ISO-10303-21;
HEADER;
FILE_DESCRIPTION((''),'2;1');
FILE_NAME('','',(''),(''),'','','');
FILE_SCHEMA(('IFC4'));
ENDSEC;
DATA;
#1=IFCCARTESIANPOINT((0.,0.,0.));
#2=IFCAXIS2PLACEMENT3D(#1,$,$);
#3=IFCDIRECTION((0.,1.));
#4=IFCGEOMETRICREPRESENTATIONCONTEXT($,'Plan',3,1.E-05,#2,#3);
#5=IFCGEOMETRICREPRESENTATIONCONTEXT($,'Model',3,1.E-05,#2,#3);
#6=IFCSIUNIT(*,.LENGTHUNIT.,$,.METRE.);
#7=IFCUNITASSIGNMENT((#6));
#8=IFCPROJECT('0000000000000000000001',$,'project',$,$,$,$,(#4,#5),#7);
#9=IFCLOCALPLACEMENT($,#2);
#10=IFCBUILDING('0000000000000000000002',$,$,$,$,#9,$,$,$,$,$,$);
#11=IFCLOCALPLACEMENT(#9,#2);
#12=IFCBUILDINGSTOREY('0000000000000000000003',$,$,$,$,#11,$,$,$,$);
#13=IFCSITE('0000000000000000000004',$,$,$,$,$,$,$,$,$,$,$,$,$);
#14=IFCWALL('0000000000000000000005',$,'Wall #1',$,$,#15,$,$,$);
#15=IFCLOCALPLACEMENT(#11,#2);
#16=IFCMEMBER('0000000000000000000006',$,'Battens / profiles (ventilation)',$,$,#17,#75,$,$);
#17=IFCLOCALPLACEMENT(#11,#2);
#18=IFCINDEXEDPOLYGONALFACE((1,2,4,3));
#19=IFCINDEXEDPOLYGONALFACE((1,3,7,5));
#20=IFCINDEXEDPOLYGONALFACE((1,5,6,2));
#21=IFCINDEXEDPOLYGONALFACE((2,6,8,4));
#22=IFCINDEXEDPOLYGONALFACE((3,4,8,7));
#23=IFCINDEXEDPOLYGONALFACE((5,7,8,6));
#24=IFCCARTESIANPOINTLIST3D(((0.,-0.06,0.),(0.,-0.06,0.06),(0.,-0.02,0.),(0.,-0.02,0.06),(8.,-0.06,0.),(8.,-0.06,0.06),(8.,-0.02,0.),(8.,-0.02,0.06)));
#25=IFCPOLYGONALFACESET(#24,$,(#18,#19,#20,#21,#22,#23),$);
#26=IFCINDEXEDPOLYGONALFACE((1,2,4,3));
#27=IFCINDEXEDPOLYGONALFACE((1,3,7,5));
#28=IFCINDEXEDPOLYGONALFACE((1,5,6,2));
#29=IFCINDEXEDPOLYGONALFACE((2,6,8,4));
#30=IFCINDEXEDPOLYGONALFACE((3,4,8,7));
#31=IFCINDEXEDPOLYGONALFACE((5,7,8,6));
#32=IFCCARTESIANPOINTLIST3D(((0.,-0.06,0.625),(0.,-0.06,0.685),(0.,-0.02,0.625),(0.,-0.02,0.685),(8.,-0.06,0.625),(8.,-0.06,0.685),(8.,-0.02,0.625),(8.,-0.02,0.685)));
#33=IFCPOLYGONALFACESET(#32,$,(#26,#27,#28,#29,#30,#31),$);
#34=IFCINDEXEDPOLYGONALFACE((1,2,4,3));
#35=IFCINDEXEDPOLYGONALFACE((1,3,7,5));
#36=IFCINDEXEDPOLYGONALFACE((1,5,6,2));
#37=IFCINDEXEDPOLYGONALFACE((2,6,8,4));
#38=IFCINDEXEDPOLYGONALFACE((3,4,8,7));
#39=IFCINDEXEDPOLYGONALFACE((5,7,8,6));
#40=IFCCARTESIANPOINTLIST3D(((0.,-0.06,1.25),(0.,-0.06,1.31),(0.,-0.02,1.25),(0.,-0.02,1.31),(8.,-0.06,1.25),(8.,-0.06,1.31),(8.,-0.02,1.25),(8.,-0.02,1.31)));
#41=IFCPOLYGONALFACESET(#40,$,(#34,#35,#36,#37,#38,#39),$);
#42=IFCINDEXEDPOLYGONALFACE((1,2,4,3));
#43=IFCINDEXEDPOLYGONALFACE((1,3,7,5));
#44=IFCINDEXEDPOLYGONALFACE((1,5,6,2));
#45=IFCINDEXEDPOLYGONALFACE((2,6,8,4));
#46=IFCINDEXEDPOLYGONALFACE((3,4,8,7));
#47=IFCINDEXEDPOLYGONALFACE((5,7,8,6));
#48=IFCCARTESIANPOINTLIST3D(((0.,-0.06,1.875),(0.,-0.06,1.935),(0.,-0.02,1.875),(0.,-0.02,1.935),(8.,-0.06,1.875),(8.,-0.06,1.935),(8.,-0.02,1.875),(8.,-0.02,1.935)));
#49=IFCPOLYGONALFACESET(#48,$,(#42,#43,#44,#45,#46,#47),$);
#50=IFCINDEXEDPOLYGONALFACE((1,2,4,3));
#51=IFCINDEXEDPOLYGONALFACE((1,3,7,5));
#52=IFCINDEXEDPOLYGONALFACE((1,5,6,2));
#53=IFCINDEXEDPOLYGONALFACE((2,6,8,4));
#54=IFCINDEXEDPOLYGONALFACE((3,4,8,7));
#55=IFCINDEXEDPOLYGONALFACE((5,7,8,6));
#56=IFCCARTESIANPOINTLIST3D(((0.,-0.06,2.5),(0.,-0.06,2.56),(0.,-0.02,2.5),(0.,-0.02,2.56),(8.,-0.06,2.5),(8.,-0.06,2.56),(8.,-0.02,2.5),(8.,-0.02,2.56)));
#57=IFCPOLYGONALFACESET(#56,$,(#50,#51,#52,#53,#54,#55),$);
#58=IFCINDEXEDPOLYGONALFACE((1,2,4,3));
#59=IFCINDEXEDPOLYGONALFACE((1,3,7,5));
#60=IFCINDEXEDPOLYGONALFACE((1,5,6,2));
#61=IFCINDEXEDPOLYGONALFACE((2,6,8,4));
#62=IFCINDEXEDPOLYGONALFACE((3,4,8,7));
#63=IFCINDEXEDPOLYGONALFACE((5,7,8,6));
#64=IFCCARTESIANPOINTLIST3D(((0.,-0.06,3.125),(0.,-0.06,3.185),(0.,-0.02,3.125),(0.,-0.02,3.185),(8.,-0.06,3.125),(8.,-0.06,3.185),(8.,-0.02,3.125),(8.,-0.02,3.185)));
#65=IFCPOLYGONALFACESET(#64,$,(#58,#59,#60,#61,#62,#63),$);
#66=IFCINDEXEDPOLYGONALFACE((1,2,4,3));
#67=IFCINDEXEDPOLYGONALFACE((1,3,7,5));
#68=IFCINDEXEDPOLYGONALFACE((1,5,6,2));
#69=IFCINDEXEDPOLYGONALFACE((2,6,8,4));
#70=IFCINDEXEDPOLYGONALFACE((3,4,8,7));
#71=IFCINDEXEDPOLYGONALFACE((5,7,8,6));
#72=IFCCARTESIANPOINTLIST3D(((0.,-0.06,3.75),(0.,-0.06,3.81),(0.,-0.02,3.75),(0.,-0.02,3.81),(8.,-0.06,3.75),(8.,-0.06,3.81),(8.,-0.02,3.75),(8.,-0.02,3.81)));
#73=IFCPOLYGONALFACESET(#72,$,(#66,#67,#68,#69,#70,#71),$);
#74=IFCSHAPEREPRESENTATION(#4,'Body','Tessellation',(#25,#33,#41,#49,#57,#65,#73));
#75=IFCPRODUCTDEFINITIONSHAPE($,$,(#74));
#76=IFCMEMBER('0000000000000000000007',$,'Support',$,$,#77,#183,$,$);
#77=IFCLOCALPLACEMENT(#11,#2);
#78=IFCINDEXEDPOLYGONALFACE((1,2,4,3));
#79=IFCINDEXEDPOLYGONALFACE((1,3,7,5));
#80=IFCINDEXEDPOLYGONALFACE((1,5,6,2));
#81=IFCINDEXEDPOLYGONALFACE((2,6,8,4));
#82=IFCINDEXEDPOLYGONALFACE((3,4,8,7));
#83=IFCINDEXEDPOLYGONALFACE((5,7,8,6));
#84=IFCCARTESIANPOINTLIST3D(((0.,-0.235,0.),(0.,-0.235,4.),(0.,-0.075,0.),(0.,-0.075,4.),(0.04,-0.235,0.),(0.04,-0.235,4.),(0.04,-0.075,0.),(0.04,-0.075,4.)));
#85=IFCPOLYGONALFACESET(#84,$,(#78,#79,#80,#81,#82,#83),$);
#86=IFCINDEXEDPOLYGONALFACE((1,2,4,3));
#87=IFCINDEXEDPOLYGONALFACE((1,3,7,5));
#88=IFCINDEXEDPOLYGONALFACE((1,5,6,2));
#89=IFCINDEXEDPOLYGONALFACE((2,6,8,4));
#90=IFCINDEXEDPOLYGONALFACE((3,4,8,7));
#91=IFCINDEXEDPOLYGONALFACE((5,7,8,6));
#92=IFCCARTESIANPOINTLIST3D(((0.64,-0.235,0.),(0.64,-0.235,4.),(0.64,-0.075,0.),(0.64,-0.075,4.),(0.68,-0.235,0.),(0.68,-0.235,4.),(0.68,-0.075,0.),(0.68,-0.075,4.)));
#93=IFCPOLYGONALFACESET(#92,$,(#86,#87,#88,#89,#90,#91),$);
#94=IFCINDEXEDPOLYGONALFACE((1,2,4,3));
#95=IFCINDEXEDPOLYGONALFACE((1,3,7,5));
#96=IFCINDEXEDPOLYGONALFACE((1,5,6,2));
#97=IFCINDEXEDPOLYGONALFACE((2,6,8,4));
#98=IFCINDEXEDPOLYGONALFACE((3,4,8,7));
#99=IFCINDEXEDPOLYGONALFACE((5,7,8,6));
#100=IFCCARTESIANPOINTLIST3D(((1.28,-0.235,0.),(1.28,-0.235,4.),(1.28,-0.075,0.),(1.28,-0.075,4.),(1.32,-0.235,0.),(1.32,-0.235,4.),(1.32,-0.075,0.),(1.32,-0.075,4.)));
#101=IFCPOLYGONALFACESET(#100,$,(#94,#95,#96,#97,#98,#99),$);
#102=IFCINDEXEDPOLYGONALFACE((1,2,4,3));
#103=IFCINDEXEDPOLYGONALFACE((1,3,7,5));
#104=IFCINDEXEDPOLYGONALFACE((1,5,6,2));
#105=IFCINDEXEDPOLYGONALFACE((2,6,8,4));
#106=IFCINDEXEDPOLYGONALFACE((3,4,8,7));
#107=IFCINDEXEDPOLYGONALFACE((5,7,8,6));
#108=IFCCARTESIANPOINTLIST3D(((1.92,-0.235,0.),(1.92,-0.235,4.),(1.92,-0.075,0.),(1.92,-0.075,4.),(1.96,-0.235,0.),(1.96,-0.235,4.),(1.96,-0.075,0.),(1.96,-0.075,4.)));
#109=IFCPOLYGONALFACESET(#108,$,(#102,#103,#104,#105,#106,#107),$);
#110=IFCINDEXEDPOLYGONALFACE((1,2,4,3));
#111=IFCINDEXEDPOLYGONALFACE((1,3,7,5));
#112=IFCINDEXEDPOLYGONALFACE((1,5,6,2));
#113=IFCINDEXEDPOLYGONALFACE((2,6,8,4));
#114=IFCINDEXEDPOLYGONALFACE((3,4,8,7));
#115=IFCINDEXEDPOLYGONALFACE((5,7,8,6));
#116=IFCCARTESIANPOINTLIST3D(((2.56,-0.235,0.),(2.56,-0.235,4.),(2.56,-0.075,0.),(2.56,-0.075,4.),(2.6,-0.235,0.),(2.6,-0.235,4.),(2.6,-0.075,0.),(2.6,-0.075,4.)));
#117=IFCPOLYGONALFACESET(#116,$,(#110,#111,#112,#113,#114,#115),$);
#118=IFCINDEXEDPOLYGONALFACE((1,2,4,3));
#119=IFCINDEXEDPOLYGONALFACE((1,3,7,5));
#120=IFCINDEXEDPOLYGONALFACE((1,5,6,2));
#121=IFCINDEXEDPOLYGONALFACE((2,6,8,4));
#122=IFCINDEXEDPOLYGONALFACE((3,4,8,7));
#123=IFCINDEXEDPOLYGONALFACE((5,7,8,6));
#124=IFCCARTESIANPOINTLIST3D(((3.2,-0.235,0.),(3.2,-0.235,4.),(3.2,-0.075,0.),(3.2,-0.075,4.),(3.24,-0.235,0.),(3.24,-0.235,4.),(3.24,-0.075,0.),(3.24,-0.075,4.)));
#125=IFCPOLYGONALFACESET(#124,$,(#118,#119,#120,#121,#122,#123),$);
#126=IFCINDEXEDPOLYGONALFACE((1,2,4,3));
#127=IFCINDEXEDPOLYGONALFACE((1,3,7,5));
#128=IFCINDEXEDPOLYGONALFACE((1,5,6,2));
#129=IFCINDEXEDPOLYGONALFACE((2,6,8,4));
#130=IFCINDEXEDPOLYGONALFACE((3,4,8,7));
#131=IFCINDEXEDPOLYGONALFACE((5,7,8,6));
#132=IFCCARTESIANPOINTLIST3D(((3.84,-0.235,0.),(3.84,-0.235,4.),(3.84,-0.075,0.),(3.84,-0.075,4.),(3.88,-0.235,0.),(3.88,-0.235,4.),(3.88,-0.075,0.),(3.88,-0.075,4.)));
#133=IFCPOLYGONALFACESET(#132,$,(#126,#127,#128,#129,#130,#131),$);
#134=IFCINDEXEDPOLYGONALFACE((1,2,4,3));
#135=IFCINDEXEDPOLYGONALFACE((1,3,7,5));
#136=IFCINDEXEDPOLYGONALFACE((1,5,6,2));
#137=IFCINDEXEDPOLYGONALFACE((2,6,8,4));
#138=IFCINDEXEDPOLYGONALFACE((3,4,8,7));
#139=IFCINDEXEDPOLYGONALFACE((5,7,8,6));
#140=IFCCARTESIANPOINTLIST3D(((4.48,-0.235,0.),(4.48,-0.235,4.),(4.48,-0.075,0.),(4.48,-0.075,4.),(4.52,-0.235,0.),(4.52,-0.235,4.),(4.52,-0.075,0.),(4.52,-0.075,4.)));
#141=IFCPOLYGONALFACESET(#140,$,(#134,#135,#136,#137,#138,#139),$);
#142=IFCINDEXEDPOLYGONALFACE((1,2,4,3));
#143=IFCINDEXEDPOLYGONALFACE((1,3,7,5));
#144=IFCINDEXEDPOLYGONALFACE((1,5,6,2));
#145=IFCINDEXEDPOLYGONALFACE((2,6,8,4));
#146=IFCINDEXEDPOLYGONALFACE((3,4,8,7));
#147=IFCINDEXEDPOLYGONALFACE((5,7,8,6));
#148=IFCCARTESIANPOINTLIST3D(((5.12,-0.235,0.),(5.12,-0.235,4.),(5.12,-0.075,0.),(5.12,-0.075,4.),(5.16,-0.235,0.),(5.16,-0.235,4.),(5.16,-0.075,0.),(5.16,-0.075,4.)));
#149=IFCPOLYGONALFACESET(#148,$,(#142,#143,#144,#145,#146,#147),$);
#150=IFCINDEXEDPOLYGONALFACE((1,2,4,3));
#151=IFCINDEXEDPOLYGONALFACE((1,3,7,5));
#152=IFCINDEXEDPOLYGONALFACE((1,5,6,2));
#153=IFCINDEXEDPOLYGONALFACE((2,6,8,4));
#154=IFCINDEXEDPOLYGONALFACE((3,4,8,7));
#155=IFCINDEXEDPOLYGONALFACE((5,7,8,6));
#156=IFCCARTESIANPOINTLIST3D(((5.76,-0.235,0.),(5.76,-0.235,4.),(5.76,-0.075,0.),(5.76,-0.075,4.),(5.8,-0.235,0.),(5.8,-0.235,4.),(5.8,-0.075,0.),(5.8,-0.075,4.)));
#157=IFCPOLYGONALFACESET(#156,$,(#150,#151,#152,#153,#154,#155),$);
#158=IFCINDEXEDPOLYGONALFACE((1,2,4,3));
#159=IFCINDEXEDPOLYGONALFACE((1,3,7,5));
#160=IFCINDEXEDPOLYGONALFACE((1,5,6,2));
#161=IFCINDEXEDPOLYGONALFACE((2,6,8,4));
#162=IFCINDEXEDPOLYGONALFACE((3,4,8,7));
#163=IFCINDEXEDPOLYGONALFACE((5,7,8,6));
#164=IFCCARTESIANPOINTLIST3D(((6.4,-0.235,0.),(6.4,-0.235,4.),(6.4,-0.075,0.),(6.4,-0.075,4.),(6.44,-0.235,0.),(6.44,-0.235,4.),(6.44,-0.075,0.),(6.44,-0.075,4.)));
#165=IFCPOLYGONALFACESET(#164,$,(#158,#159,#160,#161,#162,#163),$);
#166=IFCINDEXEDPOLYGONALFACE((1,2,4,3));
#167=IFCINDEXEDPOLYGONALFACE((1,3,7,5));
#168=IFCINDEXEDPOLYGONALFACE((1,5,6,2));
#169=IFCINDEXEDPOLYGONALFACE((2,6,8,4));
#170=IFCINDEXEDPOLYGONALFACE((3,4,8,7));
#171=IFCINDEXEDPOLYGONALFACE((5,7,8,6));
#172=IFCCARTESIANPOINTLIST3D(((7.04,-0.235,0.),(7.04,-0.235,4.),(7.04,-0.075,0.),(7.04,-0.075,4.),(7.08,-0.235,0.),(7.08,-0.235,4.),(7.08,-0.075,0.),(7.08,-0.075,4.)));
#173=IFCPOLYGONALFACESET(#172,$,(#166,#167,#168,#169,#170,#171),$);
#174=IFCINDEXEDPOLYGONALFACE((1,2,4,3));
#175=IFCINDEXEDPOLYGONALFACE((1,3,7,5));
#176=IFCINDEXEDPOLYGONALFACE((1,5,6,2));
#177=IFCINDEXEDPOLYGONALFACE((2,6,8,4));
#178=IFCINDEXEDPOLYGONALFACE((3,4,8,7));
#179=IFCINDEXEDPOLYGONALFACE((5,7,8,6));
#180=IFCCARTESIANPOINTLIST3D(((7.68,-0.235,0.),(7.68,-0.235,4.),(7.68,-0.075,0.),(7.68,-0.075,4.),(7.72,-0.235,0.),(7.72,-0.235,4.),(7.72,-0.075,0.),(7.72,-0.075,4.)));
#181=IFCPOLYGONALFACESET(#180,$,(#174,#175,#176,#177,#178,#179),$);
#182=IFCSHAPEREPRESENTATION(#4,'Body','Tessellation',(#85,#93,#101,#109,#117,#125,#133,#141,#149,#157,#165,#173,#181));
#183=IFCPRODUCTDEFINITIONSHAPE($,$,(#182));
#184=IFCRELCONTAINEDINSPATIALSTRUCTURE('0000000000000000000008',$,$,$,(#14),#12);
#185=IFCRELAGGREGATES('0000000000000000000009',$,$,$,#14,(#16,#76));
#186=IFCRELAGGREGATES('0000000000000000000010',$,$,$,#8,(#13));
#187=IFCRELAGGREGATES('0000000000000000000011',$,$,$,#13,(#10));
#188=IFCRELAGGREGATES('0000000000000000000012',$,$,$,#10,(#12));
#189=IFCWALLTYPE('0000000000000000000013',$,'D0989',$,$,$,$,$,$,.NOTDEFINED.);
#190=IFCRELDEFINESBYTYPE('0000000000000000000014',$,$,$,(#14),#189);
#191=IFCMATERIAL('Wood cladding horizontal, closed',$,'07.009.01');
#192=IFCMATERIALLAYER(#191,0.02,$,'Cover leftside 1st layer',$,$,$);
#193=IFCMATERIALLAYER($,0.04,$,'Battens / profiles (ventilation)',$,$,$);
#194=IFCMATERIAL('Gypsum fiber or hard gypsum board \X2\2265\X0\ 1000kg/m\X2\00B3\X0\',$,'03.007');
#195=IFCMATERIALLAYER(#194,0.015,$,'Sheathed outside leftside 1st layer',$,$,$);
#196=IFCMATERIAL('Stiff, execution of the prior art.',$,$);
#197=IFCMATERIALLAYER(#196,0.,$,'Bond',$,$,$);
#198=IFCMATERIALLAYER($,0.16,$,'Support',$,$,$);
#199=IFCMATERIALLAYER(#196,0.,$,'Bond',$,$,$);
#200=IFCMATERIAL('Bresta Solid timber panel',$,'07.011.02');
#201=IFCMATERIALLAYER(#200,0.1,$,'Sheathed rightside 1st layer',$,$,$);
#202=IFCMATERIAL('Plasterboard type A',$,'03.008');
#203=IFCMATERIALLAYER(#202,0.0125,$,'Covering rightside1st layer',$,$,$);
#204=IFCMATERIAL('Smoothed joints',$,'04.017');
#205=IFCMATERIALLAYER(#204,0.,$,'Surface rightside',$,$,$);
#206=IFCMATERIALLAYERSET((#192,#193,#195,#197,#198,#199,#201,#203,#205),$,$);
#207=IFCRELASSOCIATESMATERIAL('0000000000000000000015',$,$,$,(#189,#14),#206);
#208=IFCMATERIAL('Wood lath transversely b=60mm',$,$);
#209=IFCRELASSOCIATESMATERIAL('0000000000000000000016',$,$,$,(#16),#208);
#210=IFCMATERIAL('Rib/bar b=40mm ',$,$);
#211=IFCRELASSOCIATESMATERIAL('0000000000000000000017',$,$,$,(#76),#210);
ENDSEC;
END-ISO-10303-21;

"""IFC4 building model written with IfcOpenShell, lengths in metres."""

from ifc_helpers import new_model, si_unit, direction, frame, frame_2d, origin, place, context, project, spatial, rectangle, extrude, material, layer, layer_set, type_object, element, aggregate, save


model = new_model("IFC4")

# Units and contexts
plan_context = context("Plan", 3, precision=1e-05, world=origin(), true_north=direction((0.0, 1.0)))
model_context = context("Model", 3, precision=1e-05, world=origin(), true_north=direction((0.0, 1.0)))
ifc_project = project(units=[si_unit("LENGTHUNIT", "METRE")], contexts=[plan_context, model_context])

# Site, building, storey
site = spatial("IfcSite", under=ifc_project)
building_placement = place(None, origin())
building = spatial("IfcBuilding", under=site, at=building_placement)
storey_placement = place(building_placement, origin())
storey = spatial("IfcBuildingStorey", under=building, at=storey_placement)

# Wall, members
ifc_material_1 = material(Name="Wood cladding horizontal, closed", Category="07.009.01")
ifc_layer_1 = layer(ifc_material_1, 0.02, Name="Cover leftside 1st layer")
ifc_layer_2 = layer(None, 0.04, Name="Battens / profiles (ventilation)")
ifc_material_2 = material(Name="Gypsum fiber or hard gypsum board ≥ 1000kg/m³", Category="03.007")
ifc_layer_3 = layer(ifc_material_2, 0.015, Name="Sheathed outside leftside 1st layer")
ifc_material_3 = material(Name="Stiff, execution of the prior art.")
ifc_layer_4 = layer(ifc_material_3, 0.0, Name="Bond")
ifc_layer_5 = layer(None, 0.16, Name="Support")
ifc_layer_6 = layer(ifc_material_3, 0.0, Name="Bond")
ifc_material_4 = material(Name="Bresta Solid timber panel", Category="07.011.02")
ifc_layer_7 = layer(ifc_material_4, 0.1, Name="Sheathed rightside 1st layer")
ifc_material_5 = material(Name="Plasterboard type A", Category="03.008")
ifc_layer_8 = layer(ifc_material_5, 0.0125, Name="Covering rightside1st layer")
ifc_material_6 = material(Name="Smoothed joints", Category="04.017")
ifc_layer_9 = layer(ifc_material_6, 0.0, Name="Surface rightside")
ifc_layer_set = layer_set([ifc_layer_1, ifc_layer_2, ifc_layer_3, ifc_layer_4, ifc_layer_5, ifc_layer_6, ifc_layer_7, ifc_layer_8, ifc_layer_9])
wall_type = type_object("IfcWallType", Name="D0989", PredefinedType="NOTDEFINED", material=ifc_layer_set)
wall_placement = place(None, frame((0.0, 0.0, 0.0), z_axis=(0.0, -1.0, 0.0), x_axis=(1.0, 0.0, 0.0)))
wall = element("IfcWall", 1, at=wall_placement, inside=storey, type_object=wall_type, material=ifc_layer_set, Name="Wall #1")
ifc_material_7 = material(Name="Wood lath transversely b=60mm")
member_1_placement = place(wall_placement, origin())
member_1 = element("IfcMember", 2, at=member_1_placement, material=ifc_material_7, Name="Battens / profiles (ventilation)", context=plan_context, shape_type="SweptSolid", body=[
    extrude(rectangle(XDim=0.06, YDim=0.04, at=frame_2d((0.03, 0.02), x_axis=(1.0, 0.0))), frame((0.0, 0.0, 0.02), z_axis=(1.0, 0.0, 0.0), x_axis=(0.0, 1.0, 0.0)), (0.0, 0.0, 1.0), 8.0),
    extrude(rectangle(XDim=0.06, YDim=0.04, at=frame_2d((0.03, 0.02), x_axis=(1.0, 0.0))), frame((0.0, 0.625, 0.02), z_axis=(1.0, 0.0, 0.0), x_axis=(0.0, 1.0, 0.0)), (0.0, 0.0, 1.0), 8.0),
    extrude(rectangle(XDim=0.06, YDim=0.04, at=frame_2d((0.03, 0.02), x_axis=(1.0, 0.0))), frame((0.0, 1.25, 0.02), z_axis=(1.0, 0.0, 0.0), x_axis=(0.0, 1.0, 0.0)), (0.0, 0.0, 1.0), 8.0),
    extrude(rectangle(XDim=0.06, YDim=0.04, at=frame_2d((0.03, 0.02), x_axis=(1.0, 0.0))), frame((0.0, 1.875, 0.02), z_axis=(1.0, 0.0, 0.0), x_axis=(0.0, 1.0, 0.0)), (0.0, 0.0, 1.0), 8.0),
    extrude(rectangle(XDim=0.06, YDim=0.04, at=frame_2d((0.03, 0.02), x_axis=(1.0, 0.0))), frame((0.0, 2.5, 0.02), z_axis=(1.0, 0.0, 0.0), x_axis=(0.0, 1.0, 0.0)), (0.0, 0.0, 1.0), 8.0),
    extrude(rectangle(XDim=0.06, YDim=0.04, at=frame_2d((0.03, 0.02), x_axis=(1.0, 0.0))), frame((0.0, 3.125, 0.02), z_axis=(1.0, 0.0, 0.0), x_axis=(0.0, 1.0, 0.0)), (0.0, 0.0, 1.0), 8.0),
    extrude(rectangle(XDim=0.06, YDim=0.04, at=frame_2d((0.03, 0.02), x_axis=(1.0, 0.0))), frame((0.0, 3.75, 0.02), z_axis=(1.0, 0.0, 0.0), x_axis=(0.0, 1.0, 0.0)), (0.0, 0.0, 1.0), 8.0),
])
ifc_material_8 = material(Name="Rib/bar b=40mm ")
member_2_placement = place(wall_placement, origin())
member_2 = element("IfcMember", 3, at=member_2_placement, material=ifc_material_8, Name="Support", context=plan_context, shape_type="SweptSolid", body=[
    extrude(rectangle(XDim=0.04, YDim=0.16, at=frame_2d((0.02, 0.08), x_axis=(1.0, 0.0))), frame((0.0, 4.0, 0.075), z_axis=(0.0, -1.0, 0.0), x_axis=(1.0, 0.0, 0.0)), (0.0, 0.0, 1.0), 4.0),
    extrude(rectangle(XDim=0.04, YDim=0.16, at=frame_2d((0.02, 0.08), x_axis=(1.0, 0.0))), frame((0.64, 4.0, 0.075), z_axis=(0.0, -1.0, 0.0), x_axis=(1.0, 0.0, 0.0)), (0.0, 0.0, 1.0), 4.0),
    extrude(rectangle(XDim=0.04, YDim=0.16, at=frame_2d((0.02, 0.08), x_axis=(1.0, 0.0))), frame((1.28, 4.0, 0.075), z_axis=(0.0, -1.0, 0.0), x_axis=(1.0, 0.0, 0.0)), (0.0, 0.0, 1.0), 4.0),
    extrude(rectangle(XDim=0.04, YDim=0.16, at=frame_2d((0.02, 0.08), x_axis=(1.0, 0.0))), frame((1.92, 4.0, 0.075), z_axis=(0.0, -1.0, 0.0), x_axis=(1.0, 0.0, 0.0)), (0.0, 0.0, 1.0), 4.0),
    extrude(rectangle(XDim=0.04, YDim=0.16, at=frame_2d((0.02, 0.08), x_axis=(1.0, 0.0))), frame((2.56, 4.0, 0.075), z_axis=(0.0, -1.0, 0.0), x_axis=(1.0, 0.0, 0.0)), (0.0, 0.0, 1.0), 4.0),
    extrude(rectangle(XDim=0.04, YDim=0.16, at=frame_2d((0.02, 0.08), x_axis=(1.0, 0.0))), frame((3.2, 4.0, 0.075), z_axis=(0.0, -1.0, 0.0), x_axis=(1.0, 0.0, 0.0)), (0.0, 0.0, 1.0), 4.0),
    extrude(rectangle(XDim=0.04, YDim=0.16, at=frame_2d((0.02, 0.08), x_axis=(1.0, 0.0))), frame((3.84, 4.0, 0.075), z_axis=(0.0, -1.0, 0.0), x_axis=(1.0, 0.0, 0.0)), (0.0, 0.0, 1.0), 4.0),
    extrude(rectangle(XDim=0.04, YDim=0.16, at=frame_2d((0.02, 0.08), x_axis=(1.0, 0.0))), frame((4.48, 4.0, 0.075), z_axis=(0.0, -1.0, 0.0), x_axis=(1.0, 0.0, 0.0)), (0.0, 0.0, 1.0), 4.0),
    extrude(rectangle(XDim=0.04, YDim=0.16, at=frame_2d((0.02, 0.08), x_axis=(1.0, 0.0))), frame((5.12, 4.0, 0.075), z_axis=(0.0, -1.0, 0.0), x_axis=(1.0, 0.0, 0.0)), (0.0, 0.0, 1.0), 4.0),
    extrude(rectangle(XDim=0.04, YDim=0.16, at=frame_2d((0.02, 0.08), x_axis=(1.0, 0.0))), frame((5.76, 4.0, 0.075), z_axis=(0.0, -1.0, 0.0), x_axis=(1.0, 0.0, 0.0)), (0.0, 0.0, 1.0), 4.0),
    extrude(rectangle(XDim=0.04, YDim=0.16, at=frame_2d((0.02, 0.08), x_axis=(1.0, 0.0))), frame((6.4, 4.0, 0.075), z_axis=(0.0, -1.0, 0.0), x_axis=(1.0, 0.0, 0.0)), (0.0, 0.0, 1.0), 4.0),
    extrude(rectangle(XDim=0.04, YDim=0.16, at=frame_2d((0.02, 0.08), x_axis=(1.0, 0.0))), frame((7.04, 4.0, 0.075), z_axis=(0.0, -1.0, 0.0), x_axis=(1.0, 0.0, 0.0)), (0.0, 0.0, 1.0), 4.0),
    extrude(rectangle(XDim=0.04, YDim=0.16, at=frame_2d((0.02, 0.08), x_axis=(1.0, 0.0))), frame((7.68, 4.0, 0.075), z_axis=(0.0, -1.0, 0.0), x_axis=(1.0, 0.0, 0.0)), (0.0, 0.0, 1.0), 4.0),
])
aggregate(wall, [member_1, member_2])

save(model, "model.ifc")
